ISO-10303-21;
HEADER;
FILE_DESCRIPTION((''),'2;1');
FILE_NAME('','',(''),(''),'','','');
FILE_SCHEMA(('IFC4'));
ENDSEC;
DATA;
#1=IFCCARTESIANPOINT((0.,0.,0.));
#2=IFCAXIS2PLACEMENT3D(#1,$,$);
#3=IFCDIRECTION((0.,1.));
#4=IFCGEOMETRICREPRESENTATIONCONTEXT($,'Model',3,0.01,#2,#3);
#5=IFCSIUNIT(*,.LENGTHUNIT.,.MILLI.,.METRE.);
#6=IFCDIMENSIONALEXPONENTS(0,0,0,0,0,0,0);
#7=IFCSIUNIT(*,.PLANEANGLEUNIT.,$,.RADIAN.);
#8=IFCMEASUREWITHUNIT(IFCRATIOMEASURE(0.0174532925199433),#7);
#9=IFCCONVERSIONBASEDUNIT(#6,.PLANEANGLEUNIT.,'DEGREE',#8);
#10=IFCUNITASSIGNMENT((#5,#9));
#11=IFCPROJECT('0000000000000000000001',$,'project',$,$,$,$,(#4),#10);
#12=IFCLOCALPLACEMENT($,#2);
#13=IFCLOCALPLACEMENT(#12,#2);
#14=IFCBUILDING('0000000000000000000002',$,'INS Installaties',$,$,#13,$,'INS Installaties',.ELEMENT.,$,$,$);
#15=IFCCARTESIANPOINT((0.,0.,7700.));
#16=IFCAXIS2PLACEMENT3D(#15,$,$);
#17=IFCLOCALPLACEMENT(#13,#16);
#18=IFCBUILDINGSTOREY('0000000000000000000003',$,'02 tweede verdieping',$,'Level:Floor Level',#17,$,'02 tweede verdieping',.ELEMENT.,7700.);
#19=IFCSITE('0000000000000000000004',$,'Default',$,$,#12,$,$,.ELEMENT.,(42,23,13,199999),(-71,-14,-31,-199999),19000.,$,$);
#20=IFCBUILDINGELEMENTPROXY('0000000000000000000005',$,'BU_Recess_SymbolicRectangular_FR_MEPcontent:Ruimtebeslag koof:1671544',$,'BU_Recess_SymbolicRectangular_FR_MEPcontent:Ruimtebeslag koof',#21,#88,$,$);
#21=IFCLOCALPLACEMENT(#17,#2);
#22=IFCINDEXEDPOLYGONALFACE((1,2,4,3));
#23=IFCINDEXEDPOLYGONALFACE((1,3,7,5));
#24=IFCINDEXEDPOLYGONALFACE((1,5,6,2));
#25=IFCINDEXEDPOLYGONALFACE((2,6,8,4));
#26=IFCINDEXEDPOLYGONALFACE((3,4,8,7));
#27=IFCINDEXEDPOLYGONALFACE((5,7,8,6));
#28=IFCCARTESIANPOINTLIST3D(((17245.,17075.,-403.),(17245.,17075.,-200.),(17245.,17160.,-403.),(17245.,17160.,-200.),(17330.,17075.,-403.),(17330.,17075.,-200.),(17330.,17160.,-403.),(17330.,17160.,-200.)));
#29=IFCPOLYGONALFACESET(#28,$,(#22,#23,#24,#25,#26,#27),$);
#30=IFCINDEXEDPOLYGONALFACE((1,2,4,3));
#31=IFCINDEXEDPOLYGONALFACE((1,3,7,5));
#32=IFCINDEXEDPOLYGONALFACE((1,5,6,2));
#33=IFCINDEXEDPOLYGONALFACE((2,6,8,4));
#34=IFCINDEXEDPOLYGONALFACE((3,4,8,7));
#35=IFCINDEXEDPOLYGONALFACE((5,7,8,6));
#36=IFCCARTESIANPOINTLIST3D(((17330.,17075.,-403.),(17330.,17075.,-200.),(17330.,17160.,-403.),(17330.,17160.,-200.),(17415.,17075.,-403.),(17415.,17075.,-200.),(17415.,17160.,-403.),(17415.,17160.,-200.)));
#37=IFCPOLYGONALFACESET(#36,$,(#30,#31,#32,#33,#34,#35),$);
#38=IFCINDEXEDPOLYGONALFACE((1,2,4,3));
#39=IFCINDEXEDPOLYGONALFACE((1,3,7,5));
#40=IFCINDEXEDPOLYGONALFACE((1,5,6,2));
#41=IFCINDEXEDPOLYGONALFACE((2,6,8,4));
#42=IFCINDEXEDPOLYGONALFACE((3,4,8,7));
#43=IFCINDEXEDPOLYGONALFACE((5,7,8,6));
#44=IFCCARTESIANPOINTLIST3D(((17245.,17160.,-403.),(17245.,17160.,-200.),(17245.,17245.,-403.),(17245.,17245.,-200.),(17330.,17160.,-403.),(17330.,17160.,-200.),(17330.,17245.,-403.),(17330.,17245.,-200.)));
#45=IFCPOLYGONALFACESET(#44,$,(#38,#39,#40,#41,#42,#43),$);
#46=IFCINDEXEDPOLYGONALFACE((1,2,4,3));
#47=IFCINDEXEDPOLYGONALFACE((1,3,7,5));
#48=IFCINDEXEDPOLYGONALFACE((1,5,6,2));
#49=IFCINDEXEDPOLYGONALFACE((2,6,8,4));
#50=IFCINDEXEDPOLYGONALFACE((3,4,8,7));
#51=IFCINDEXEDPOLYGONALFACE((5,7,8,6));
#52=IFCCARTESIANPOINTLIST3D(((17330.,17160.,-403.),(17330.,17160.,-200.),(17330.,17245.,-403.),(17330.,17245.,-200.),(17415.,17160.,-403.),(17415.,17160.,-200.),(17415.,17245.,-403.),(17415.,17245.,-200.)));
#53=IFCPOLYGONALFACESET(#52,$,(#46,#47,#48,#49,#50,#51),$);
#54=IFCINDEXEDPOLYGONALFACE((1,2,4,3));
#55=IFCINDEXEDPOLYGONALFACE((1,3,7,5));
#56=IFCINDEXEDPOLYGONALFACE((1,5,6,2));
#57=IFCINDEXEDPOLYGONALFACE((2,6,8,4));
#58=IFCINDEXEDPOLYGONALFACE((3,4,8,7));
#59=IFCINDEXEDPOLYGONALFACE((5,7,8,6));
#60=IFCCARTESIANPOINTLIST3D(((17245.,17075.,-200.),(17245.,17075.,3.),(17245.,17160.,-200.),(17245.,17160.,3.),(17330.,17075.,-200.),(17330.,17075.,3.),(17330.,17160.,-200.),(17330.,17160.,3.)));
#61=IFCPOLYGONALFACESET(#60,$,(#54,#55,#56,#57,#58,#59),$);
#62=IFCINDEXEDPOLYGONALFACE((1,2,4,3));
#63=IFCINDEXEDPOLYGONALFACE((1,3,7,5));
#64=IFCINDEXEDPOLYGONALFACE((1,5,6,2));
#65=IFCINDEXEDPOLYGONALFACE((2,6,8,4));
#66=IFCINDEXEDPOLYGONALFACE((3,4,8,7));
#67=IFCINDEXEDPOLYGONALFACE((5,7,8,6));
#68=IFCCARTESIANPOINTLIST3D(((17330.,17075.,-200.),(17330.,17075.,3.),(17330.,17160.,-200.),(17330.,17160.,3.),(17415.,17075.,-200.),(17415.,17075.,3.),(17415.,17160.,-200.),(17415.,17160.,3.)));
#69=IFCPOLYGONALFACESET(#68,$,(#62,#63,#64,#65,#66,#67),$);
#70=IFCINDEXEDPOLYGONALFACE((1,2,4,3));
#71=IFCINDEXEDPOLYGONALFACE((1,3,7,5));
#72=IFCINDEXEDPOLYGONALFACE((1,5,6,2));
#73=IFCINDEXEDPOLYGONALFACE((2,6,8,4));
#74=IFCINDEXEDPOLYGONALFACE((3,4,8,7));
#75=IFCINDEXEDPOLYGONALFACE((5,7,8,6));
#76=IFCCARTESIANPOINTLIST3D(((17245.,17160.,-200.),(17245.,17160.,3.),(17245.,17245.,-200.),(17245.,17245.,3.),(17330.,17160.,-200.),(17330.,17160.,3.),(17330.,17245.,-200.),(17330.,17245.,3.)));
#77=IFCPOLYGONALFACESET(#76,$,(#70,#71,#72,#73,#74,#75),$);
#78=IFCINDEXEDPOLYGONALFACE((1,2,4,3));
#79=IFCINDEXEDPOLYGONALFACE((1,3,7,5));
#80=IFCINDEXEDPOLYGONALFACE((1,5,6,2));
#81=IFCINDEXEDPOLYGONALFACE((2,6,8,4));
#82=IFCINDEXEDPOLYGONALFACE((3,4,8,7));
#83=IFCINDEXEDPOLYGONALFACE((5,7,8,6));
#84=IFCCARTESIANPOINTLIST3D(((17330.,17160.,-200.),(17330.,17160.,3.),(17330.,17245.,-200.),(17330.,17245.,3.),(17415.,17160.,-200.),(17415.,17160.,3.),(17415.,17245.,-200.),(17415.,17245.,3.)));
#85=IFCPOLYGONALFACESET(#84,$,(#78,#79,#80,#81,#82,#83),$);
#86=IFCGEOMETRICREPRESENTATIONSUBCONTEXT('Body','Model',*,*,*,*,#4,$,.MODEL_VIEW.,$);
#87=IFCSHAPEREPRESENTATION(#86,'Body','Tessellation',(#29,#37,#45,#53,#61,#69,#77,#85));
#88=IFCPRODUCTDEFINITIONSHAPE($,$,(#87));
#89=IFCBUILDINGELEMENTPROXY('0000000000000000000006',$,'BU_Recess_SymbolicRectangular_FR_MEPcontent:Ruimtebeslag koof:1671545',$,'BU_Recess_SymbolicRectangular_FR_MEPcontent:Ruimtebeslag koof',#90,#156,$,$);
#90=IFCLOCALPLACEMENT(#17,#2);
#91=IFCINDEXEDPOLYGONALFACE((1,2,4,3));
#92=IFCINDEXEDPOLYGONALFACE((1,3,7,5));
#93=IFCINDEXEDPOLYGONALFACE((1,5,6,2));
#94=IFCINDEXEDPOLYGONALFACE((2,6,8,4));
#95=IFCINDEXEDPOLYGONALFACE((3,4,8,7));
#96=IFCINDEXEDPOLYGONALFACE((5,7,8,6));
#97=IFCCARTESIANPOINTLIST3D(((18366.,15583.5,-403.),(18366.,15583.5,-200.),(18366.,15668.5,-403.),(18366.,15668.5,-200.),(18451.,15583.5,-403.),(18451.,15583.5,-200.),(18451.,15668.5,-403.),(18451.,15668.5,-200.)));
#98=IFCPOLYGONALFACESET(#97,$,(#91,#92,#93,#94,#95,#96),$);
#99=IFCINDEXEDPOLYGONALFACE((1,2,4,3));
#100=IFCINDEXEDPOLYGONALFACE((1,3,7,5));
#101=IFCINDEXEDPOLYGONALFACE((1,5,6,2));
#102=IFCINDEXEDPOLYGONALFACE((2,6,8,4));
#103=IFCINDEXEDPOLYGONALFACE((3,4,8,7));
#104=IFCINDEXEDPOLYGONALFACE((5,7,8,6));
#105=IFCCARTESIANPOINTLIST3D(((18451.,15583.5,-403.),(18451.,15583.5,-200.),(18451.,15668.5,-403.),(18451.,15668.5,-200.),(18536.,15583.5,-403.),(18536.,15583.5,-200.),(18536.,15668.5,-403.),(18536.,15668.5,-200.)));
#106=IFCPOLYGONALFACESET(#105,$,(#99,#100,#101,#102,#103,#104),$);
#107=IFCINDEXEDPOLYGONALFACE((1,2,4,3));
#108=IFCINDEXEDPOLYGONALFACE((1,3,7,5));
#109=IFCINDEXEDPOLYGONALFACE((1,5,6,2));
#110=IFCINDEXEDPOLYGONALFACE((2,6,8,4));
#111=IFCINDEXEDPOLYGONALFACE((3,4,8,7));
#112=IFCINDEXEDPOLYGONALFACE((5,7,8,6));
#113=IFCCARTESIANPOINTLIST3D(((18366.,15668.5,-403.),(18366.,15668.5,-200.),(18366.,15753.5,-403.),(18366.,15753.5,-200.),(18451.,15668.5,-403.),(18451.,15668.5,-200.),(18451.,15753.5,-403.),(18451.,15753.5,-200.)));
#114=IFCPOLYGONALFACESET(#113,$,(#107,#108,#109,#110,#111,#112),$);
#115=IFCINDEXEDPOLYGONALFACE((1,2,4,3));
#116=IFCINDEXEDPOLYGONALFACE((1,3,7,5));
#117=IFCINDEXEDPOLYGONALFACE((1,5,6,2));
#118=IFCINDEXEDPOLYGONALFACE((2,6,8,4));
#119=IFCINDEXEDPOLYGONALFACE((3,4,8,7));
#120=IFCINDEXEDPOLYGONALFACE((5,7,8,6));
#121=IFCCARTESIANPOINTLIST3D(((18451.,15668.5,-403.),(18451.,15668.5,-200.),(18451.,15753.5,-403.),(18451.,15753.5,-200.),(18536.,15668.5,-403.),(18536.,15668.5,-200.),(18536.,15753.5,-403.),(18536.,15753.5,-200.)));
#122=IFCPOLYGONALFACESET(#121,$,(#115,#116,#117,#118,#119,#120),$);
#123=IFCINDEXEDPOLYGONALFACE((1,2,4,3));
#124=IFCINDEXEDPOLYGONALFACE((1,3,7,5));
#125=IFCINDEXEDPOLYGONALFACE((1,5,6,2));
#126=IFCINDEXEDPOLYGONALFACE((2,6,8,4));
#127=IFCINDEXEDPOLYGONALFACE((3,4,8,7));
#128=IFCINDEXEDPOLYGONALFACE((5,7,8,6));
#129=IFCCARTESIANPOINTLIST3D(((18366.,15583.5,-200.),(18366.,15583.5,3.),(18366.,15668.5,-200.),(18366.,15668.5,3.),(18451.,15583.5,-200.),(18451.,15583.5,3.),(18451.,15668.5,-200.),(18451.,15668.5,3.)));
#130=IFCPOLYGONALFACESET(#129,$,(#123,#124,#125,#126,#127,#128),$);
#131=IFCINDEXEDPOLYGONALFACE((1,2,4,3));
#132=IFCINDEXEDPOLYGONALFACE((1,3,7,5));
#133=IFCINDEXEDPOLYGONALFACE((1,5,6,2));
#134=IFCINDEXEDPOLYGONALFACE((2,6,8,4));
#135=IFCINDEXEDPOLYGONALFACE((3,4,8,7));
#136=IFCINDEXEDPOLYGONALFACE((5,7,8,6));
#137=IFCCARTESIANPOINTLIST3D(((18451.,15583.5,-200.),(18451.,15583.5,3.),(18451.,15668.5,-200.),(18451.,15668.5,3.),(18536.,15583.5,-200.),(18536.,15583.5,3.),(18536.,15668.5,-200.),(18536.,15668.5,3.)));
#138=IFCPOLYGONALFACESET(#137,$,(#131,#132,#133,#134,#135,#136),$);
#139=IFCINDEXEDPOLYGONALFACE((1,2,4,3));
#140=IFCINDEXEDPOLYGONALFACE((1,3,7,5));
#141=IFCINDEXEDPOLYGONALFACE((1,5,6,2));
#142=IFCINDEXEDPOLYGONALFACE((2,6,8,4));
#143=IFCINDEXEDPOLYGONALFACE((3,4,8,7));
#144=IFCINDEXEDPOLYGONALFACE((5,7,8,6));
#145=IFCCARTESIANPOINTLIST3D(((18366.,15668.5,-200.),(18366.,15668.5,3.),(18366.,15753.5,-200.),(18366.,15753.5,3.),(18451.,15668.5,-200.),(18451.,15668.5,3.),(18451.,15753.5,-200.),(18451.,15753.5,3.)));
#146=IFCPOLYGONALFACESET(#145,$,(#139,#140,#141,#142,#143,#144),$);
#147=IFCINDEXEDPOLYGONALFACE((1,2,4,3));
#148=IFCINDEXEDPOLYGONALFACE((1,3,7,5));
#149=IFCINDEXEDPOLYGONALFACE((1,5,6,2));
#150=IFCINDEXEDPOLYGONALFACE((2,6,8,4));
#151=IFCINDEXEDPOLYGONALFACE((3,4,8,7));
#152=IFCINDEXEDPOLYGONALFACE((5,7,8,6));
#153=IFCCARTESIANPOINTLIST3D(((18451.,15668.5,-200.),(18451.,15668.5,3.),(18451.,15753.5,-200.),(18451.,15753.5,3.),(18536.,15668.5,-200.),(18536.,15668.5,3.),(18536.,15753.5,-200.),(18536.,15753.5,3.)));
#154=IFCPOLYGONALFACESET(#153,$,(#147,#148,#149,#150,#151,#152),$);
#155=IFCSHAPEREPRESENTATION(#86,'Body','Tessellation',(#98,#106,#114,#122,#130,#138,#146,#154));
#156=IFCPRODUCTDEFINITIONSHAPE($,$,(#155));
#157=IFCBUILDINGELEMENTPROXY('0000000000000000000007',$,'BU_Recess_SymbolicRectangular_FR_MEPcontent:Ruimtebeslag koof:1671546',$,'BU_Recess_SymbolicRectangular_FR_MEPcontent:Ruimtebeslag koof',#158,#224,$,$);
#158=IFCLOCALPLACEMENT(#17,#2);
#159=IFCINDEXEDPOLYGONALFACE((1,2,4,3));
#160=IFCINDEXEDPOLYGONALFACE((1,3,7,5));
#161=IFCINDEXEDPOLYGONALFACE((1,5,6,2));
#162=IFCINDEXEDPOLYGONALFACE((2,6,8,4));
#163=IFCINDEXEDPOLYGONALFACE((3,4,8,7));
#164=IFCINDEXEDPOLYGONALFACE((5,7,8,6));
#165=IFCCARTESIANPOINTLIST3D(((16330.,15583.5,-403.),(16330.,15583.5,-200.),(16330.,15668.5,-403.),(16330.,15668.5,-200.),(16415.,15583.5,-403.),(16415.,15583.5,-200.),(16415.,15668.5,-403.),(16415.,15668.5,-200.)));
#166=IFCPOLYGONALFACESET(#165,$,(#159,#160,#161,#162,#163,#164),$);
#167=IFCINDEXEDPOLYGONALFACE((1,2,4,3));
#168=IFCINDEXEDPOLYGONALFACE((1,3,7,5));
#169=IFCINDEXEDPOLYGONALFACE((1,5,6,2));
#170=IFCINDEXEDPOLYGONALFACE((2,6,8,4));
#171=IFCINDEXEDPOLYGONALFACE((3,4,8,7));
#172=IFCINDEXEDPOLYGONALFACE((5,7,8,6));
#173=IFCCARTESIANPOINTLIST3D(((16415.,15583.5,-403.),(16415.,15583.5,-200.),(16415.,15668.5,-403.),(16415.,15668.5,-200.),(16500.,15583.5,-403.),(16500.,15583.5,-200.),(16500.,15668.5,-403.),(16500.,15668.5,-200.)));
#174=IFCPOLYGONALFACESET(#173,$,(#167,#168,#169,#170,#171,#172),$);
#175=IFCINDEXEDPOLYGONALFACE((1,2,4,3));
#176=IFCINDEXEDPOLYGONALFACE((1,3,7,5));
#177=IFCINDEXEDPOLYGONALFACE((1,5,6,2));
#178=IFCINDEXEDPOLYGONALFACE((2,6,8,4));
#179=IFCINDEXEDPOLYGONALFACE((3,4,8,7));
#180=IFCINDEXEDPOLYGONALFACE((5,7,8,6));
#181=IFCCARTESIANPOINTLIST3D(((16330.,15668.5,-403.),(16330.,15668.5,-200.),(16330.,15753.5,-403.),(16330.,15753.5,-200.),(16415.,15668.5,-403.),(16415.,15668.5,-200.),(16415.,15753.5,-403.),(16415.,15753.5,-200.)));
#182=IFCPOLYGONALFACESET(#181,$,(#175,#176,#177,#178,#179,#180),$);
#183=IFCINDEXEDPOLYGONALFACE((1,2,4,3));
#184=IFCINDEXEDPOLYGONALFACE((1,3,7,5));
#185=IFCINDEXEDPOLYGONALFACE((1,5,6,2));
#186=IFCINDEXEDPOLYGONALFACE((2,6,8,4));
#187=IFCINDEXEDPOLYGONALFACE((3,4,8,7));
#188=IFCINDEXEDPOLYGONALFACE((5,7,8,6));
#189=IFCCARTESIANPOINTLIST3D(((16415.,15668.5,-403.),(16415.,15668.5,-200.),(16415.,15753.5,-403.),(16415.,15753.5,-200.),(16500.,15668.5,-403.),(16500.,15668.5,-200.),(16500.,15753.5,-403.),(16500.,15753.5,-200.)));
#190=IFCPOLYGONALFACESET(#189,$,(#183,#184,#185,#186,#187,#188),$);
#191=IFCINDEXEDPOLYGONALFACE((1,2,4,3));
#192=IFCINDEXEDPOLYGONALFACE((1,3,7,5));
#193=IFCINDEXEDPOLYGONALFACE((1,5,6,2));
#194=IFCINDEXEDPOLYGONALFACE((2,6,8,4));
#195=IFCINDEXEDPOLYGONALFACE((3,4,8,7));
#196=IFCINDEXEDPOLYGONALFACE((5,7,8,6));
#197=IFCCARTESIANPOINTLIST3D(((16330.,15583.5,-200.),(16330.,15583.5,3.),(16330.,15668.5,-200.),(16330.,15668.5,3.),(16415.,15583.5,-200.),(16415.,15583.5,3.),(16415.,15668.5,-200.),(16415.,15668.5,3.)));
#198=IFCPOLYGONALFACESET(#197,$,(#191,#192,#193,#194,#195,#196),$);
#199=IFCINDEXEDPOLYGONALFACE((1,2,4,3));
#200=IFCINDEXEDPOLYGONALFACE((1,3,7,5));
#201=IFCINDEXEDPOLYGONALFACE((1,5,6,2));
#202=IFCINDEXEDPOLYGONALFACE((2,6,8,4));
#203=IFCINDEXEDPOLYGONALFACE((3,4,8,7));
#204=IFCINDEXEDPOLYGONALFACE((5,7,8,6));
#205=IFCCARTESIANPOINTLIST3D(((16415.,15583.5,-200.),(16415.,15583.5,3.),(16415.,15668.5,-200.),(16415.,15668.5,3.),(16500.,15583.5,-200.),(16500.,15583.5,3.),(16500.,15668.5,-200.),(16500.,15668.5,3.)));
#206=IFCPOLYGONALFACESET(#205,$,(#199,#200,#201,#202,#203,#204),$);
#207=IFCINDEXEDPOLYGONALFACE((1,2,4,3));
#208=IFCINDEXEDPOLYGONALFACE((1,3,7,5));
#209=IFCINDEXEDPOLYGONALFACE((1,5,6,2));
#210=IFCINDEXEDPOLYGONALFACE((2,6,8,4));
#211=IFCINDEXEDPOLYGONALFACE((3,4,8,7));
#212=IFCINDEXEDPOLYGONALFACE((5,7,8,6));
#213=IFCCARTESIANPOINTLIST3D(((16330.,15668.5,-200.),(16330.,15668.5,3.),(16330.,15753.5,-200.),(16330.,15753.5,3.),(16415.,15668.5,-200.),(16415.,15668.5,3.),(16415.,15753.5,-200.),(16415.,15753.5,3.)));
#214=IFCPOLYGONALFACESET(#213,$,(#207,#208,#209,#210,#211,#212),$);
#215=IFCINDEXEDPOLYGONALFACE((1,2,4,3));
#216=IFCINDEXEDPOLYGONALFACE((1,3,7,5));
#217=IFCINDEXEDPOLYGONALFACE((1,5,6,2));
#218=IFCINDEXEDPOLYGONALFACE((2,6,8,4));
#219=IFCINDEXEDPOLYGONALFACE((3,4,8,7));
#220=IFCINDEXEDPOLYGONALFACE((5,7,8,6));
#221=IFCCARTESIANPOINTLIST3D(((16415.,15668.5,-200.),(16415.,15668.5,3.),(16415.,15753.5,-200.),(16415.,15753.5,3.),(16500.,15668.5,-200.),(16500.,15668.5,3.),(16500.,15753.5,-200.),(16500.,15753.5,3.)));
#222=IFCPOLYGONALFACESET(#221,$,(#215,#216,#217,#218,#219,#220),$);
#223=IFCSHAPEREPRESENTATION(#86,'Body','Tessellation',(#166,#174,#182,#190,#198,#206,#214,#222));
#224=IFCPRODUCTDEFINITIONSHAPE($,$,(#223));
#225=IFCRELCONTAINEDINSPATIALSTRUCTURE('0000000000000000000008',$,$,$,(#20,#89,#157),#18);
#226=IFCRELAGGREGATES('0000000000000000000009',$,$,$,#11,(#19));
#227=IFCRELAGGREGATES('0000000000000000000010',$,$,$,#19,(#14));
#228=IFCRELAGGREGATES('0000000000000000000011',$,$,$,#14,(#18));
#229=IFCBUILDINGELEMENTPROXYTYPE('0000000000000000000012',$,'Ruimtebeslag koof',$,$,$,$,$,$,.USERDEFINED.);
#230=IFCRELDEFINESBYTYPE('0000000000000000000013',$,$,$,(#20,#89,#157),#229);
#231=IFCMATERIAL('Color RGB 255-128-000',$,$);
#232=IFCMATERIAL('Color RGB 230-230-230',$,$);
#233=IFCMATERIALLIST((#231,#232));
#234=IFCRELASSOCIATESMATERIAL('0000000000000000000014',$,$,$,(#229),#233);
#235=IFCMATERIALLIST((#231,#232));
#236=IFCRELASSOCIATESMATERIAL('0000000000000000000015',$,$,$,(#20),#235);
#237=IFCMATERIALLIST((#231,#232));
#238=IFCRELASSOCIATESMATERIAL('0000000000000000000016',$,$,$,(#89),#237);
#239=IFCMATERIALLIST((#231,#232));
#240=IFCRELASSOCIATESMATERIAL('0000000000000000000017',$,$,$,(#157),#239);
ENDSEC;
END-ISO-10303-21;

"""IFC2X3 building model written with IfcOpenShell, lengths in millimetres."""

from ifc_helpers import new_model, entity, si_unit, converted_unit, direction, frame, frame_2d, origin, origin_2d_with_axis, place, context, subcontext, project, spatial, rectangle, extrude, source, transform, mapped, material, material_list, type_object, type_shapes, element, save


model = new_model("IFC2X3")

# Units and contexts
model_context = context("Model", 3, precision=0.01, world=origin(), true_north=direction((0.0, 1.0)))
body_context = subcontext(model_context, "Body", "Model", "MODEL_VIEW")
ifc_project = project(units=[si_unit("LENGTHUNIT", "METRE", prefix="MILLI"), converted_unit("PLANEANGLEUNIT", "DEGREE", entity("IfcRatioMeasure", 0.0174532925199433), si_unit("PLANEANGLEUNIT", "RADIAN"), dimensions=[0, 0, 0, 0, 0, 0, 0])], contexts=[model_context])

# Site, building, storey
site_placement = place(None, origin())
site = spatial("IfcSite", under=ifc_project, at=site_placement, Name="Default", CompositionType="ELEMENT", RefLatitude=(42, 23, 13, 199999), RefLongitude=(-71, -14, -31, -199999), RefElevation=19000.0)
building_placement = place(site_placement, origin())
building = spatial("IfcBuilding", under=site, at=building_placement, Name="INS Installaties", LongName="INS Installaties", CompositionType="ELEMENT")
storey_placement = place(building_placement, frame((0.0, 0.0, 7700.0)))
storey = spatial("IfcBuildingStorey", under=building, at=storey_placement, Name="02 tweede verdieping", ObjectType="Level:Floor Level", LongName="02 tweede verdieping", CompositionType="ELEMENT", Elevation=7700.0)

# Building element proxies
ifc_material_1 = material(Name="Color RGB 255-128-000")
ifc_material_2 = material(Name="Color RGB 230-230-230")
ifc_material_list_1 = material_list([ifc_material_1, ifc_material_2])
building_element_proxy_type_1 = type_object("IfcBuildingElementProxyType", Name="Ruimtebeslag koof", PredefinedType="USERDEFINED", material=ifc_material_list_1)
shared_shape_1 = source(origin(), body_context, "Body", "SweptSolid", [
    extrude(rectangle(XDim=85.0, YDim=85.0, at=origin_2d_with_axis()), frame((42.5, 42.5, -403.0), z_axis=(0.0, 0.0, 1.0), x_axis=(0.0, -1.0, 0.0)), (0.0, 0.0, 1.0), 203.0),
    extrude(rectangle(XDim=85.0, YDim=85.0, at=origin_2d_with_axis()), frame((-42.5, 42.5, -403.0), z_axis=(0.0, 0.0, 1.0), x_axis=(-1.0, 0.0, 0.0)), (0.0, 0.0, 1.0), 203.0),
    extrude(rectangle(XDim=85.0, YDim=85.0, at=frame_2d((0.0, 0.0), x_axis=(1.0, 0.0))), frame((42.5, -42.5, -403.0)), (0.0, 0.0, 1.0), 203.0),
    extrude(rectangle(XDim=85.0, YDim=85.0, at=origin_2d_with_axis()), frame((-42.5, -42.5, -403.0), z_axis=(0.0, 0.0, 1.0), x_axis=(0.0, 1.0, 0.0)), (0.0, 0.0, 1.0), 203.0),
    extrude(rectangle(XDim=85.0, YDim=85.0, at=origin_2d_with_axis()), frame((42.5, 42.5, -200.0), z_axis=(0.0, 0.0, 1.0), x_axis=(0.0, -1.0, 0.0)), (0.0, 0.0, 1.0), 203.0),
    extrude(rectangle(XDim=85.0, YDim=85.0, at=frame_2d((0.0, 0.0), x_axis=(1.0, 0.0))), frame((-42.5, 42.5, -200.0), z_axis=(0.0, 0.0, 1.0), x_axis=(-1.0, 0.0, 0.0)), (0.0, 0.0, 1.0), 203.0),
    extrude(rectangle(XDim=85.0, YDim=85.0, at=frame_2d((0.0, 0.0), x_axis=(1.0, 0.0))), frame((42.5, -42.5, -200.0)), (0.0, 0.0, 1.0), 203.0),
    extrude(rectangle(XDim=85.0, YDim=85.0, at=origin_2d_with_axis()), frame((-42.5, -42.5, -200.0), z_axis=(0.0, 0.0, 1.0), x_axis=(0.0, 1.0, 0.0)), (0.0, 0.0, 1.0), 203.0),
])
type_shapes(building_element_proxy_type_1, [shared_shape_1])
ifc_material_list_2 = material_list([ifc_material_1, ifc_material_2])
proxy_1_placement = place(storey_placement, frame((17330.0, 17160.0, 0.0), z_axis=(0.0, 0.0, 1.0), x_axis=(-1.0, 0.0, 0.0)))
element("IfcBuildingElementProxy", 1, at=proxy_1_placement, inside=storey, type_object=building_element_proxy_type_1, material=ifc_material_list_2, Name="BU_Recess_SymbolicRectangular_FR_MEPcontent:Ruimtebeslag koof:1671544", ObjectType="BU_Recess_SymbolicRectangular_FR_MEPcontent:Ruimtebeslag koof", context=body_context, shape_type="MappedRepresentation", body=[
    mapped(shared_shape_1, transform((0.0, 0.0, 0.0), scale=1.0)),
])
ifc_material_list_3 = material_list([ifc_material_1, ifc_material_2])
proxy_2_placement = place(storey_placement, frame((18451.0, 15668.5, 0.0), z_axis=(0.0, 0.0, 1.0), x_axis=(-1.0, 0.0, 0.0)))
element("IfcBuildingElementProxy", 2, at=proxy_2_placement, inside=storey, type_object=building_element_proxy_type_1, material=ifc_material_list_3, Name="BU_Recess_SymbolicRectangular_FR_MEPcontent:Ruimtebeslag koof:1671545", ObjectType="BU_Recess_SymbolicRectangular_FR_MEPcontent:Ruimtebeslag koof", context=body_context, shape_type="MappedRepresentation", body=[
    mapped(shared_shape_1, transform((0.0, 0.0, 0.0), scale=1.0)),
])
ifc_material_list_4 = material_list([ifc_material_1, ifc_material_2])
proxy_3_placement = place(storey_placement, frame((16415.0, 15668.5, 0.0), z_axis=(0.0, 0.0, 1.0), x_axis=(-1.0, 0.0, 0.0)))
element("IfcBuildingElementProxy", 3, at=proxy_3_placement, inside=storey, type_object=building_element_proxy_type_1, material=ifc_material_list_4, Name="BU_Recess_SymbolicRectangular_FR_MEPcontent:Ruimtebeslag koof:1671546", ObjectType="BU_Recess_SymbolicRectangular_FR_MEPcontent:Ruimtebeslag koof", context=body_context, shape_type="MappedRepresentation", body=[
    mapped(shared_shape_1, transform((0.0, 0.0, 0.0), scale=1.0)),
])

save(model, "model.ifc")
